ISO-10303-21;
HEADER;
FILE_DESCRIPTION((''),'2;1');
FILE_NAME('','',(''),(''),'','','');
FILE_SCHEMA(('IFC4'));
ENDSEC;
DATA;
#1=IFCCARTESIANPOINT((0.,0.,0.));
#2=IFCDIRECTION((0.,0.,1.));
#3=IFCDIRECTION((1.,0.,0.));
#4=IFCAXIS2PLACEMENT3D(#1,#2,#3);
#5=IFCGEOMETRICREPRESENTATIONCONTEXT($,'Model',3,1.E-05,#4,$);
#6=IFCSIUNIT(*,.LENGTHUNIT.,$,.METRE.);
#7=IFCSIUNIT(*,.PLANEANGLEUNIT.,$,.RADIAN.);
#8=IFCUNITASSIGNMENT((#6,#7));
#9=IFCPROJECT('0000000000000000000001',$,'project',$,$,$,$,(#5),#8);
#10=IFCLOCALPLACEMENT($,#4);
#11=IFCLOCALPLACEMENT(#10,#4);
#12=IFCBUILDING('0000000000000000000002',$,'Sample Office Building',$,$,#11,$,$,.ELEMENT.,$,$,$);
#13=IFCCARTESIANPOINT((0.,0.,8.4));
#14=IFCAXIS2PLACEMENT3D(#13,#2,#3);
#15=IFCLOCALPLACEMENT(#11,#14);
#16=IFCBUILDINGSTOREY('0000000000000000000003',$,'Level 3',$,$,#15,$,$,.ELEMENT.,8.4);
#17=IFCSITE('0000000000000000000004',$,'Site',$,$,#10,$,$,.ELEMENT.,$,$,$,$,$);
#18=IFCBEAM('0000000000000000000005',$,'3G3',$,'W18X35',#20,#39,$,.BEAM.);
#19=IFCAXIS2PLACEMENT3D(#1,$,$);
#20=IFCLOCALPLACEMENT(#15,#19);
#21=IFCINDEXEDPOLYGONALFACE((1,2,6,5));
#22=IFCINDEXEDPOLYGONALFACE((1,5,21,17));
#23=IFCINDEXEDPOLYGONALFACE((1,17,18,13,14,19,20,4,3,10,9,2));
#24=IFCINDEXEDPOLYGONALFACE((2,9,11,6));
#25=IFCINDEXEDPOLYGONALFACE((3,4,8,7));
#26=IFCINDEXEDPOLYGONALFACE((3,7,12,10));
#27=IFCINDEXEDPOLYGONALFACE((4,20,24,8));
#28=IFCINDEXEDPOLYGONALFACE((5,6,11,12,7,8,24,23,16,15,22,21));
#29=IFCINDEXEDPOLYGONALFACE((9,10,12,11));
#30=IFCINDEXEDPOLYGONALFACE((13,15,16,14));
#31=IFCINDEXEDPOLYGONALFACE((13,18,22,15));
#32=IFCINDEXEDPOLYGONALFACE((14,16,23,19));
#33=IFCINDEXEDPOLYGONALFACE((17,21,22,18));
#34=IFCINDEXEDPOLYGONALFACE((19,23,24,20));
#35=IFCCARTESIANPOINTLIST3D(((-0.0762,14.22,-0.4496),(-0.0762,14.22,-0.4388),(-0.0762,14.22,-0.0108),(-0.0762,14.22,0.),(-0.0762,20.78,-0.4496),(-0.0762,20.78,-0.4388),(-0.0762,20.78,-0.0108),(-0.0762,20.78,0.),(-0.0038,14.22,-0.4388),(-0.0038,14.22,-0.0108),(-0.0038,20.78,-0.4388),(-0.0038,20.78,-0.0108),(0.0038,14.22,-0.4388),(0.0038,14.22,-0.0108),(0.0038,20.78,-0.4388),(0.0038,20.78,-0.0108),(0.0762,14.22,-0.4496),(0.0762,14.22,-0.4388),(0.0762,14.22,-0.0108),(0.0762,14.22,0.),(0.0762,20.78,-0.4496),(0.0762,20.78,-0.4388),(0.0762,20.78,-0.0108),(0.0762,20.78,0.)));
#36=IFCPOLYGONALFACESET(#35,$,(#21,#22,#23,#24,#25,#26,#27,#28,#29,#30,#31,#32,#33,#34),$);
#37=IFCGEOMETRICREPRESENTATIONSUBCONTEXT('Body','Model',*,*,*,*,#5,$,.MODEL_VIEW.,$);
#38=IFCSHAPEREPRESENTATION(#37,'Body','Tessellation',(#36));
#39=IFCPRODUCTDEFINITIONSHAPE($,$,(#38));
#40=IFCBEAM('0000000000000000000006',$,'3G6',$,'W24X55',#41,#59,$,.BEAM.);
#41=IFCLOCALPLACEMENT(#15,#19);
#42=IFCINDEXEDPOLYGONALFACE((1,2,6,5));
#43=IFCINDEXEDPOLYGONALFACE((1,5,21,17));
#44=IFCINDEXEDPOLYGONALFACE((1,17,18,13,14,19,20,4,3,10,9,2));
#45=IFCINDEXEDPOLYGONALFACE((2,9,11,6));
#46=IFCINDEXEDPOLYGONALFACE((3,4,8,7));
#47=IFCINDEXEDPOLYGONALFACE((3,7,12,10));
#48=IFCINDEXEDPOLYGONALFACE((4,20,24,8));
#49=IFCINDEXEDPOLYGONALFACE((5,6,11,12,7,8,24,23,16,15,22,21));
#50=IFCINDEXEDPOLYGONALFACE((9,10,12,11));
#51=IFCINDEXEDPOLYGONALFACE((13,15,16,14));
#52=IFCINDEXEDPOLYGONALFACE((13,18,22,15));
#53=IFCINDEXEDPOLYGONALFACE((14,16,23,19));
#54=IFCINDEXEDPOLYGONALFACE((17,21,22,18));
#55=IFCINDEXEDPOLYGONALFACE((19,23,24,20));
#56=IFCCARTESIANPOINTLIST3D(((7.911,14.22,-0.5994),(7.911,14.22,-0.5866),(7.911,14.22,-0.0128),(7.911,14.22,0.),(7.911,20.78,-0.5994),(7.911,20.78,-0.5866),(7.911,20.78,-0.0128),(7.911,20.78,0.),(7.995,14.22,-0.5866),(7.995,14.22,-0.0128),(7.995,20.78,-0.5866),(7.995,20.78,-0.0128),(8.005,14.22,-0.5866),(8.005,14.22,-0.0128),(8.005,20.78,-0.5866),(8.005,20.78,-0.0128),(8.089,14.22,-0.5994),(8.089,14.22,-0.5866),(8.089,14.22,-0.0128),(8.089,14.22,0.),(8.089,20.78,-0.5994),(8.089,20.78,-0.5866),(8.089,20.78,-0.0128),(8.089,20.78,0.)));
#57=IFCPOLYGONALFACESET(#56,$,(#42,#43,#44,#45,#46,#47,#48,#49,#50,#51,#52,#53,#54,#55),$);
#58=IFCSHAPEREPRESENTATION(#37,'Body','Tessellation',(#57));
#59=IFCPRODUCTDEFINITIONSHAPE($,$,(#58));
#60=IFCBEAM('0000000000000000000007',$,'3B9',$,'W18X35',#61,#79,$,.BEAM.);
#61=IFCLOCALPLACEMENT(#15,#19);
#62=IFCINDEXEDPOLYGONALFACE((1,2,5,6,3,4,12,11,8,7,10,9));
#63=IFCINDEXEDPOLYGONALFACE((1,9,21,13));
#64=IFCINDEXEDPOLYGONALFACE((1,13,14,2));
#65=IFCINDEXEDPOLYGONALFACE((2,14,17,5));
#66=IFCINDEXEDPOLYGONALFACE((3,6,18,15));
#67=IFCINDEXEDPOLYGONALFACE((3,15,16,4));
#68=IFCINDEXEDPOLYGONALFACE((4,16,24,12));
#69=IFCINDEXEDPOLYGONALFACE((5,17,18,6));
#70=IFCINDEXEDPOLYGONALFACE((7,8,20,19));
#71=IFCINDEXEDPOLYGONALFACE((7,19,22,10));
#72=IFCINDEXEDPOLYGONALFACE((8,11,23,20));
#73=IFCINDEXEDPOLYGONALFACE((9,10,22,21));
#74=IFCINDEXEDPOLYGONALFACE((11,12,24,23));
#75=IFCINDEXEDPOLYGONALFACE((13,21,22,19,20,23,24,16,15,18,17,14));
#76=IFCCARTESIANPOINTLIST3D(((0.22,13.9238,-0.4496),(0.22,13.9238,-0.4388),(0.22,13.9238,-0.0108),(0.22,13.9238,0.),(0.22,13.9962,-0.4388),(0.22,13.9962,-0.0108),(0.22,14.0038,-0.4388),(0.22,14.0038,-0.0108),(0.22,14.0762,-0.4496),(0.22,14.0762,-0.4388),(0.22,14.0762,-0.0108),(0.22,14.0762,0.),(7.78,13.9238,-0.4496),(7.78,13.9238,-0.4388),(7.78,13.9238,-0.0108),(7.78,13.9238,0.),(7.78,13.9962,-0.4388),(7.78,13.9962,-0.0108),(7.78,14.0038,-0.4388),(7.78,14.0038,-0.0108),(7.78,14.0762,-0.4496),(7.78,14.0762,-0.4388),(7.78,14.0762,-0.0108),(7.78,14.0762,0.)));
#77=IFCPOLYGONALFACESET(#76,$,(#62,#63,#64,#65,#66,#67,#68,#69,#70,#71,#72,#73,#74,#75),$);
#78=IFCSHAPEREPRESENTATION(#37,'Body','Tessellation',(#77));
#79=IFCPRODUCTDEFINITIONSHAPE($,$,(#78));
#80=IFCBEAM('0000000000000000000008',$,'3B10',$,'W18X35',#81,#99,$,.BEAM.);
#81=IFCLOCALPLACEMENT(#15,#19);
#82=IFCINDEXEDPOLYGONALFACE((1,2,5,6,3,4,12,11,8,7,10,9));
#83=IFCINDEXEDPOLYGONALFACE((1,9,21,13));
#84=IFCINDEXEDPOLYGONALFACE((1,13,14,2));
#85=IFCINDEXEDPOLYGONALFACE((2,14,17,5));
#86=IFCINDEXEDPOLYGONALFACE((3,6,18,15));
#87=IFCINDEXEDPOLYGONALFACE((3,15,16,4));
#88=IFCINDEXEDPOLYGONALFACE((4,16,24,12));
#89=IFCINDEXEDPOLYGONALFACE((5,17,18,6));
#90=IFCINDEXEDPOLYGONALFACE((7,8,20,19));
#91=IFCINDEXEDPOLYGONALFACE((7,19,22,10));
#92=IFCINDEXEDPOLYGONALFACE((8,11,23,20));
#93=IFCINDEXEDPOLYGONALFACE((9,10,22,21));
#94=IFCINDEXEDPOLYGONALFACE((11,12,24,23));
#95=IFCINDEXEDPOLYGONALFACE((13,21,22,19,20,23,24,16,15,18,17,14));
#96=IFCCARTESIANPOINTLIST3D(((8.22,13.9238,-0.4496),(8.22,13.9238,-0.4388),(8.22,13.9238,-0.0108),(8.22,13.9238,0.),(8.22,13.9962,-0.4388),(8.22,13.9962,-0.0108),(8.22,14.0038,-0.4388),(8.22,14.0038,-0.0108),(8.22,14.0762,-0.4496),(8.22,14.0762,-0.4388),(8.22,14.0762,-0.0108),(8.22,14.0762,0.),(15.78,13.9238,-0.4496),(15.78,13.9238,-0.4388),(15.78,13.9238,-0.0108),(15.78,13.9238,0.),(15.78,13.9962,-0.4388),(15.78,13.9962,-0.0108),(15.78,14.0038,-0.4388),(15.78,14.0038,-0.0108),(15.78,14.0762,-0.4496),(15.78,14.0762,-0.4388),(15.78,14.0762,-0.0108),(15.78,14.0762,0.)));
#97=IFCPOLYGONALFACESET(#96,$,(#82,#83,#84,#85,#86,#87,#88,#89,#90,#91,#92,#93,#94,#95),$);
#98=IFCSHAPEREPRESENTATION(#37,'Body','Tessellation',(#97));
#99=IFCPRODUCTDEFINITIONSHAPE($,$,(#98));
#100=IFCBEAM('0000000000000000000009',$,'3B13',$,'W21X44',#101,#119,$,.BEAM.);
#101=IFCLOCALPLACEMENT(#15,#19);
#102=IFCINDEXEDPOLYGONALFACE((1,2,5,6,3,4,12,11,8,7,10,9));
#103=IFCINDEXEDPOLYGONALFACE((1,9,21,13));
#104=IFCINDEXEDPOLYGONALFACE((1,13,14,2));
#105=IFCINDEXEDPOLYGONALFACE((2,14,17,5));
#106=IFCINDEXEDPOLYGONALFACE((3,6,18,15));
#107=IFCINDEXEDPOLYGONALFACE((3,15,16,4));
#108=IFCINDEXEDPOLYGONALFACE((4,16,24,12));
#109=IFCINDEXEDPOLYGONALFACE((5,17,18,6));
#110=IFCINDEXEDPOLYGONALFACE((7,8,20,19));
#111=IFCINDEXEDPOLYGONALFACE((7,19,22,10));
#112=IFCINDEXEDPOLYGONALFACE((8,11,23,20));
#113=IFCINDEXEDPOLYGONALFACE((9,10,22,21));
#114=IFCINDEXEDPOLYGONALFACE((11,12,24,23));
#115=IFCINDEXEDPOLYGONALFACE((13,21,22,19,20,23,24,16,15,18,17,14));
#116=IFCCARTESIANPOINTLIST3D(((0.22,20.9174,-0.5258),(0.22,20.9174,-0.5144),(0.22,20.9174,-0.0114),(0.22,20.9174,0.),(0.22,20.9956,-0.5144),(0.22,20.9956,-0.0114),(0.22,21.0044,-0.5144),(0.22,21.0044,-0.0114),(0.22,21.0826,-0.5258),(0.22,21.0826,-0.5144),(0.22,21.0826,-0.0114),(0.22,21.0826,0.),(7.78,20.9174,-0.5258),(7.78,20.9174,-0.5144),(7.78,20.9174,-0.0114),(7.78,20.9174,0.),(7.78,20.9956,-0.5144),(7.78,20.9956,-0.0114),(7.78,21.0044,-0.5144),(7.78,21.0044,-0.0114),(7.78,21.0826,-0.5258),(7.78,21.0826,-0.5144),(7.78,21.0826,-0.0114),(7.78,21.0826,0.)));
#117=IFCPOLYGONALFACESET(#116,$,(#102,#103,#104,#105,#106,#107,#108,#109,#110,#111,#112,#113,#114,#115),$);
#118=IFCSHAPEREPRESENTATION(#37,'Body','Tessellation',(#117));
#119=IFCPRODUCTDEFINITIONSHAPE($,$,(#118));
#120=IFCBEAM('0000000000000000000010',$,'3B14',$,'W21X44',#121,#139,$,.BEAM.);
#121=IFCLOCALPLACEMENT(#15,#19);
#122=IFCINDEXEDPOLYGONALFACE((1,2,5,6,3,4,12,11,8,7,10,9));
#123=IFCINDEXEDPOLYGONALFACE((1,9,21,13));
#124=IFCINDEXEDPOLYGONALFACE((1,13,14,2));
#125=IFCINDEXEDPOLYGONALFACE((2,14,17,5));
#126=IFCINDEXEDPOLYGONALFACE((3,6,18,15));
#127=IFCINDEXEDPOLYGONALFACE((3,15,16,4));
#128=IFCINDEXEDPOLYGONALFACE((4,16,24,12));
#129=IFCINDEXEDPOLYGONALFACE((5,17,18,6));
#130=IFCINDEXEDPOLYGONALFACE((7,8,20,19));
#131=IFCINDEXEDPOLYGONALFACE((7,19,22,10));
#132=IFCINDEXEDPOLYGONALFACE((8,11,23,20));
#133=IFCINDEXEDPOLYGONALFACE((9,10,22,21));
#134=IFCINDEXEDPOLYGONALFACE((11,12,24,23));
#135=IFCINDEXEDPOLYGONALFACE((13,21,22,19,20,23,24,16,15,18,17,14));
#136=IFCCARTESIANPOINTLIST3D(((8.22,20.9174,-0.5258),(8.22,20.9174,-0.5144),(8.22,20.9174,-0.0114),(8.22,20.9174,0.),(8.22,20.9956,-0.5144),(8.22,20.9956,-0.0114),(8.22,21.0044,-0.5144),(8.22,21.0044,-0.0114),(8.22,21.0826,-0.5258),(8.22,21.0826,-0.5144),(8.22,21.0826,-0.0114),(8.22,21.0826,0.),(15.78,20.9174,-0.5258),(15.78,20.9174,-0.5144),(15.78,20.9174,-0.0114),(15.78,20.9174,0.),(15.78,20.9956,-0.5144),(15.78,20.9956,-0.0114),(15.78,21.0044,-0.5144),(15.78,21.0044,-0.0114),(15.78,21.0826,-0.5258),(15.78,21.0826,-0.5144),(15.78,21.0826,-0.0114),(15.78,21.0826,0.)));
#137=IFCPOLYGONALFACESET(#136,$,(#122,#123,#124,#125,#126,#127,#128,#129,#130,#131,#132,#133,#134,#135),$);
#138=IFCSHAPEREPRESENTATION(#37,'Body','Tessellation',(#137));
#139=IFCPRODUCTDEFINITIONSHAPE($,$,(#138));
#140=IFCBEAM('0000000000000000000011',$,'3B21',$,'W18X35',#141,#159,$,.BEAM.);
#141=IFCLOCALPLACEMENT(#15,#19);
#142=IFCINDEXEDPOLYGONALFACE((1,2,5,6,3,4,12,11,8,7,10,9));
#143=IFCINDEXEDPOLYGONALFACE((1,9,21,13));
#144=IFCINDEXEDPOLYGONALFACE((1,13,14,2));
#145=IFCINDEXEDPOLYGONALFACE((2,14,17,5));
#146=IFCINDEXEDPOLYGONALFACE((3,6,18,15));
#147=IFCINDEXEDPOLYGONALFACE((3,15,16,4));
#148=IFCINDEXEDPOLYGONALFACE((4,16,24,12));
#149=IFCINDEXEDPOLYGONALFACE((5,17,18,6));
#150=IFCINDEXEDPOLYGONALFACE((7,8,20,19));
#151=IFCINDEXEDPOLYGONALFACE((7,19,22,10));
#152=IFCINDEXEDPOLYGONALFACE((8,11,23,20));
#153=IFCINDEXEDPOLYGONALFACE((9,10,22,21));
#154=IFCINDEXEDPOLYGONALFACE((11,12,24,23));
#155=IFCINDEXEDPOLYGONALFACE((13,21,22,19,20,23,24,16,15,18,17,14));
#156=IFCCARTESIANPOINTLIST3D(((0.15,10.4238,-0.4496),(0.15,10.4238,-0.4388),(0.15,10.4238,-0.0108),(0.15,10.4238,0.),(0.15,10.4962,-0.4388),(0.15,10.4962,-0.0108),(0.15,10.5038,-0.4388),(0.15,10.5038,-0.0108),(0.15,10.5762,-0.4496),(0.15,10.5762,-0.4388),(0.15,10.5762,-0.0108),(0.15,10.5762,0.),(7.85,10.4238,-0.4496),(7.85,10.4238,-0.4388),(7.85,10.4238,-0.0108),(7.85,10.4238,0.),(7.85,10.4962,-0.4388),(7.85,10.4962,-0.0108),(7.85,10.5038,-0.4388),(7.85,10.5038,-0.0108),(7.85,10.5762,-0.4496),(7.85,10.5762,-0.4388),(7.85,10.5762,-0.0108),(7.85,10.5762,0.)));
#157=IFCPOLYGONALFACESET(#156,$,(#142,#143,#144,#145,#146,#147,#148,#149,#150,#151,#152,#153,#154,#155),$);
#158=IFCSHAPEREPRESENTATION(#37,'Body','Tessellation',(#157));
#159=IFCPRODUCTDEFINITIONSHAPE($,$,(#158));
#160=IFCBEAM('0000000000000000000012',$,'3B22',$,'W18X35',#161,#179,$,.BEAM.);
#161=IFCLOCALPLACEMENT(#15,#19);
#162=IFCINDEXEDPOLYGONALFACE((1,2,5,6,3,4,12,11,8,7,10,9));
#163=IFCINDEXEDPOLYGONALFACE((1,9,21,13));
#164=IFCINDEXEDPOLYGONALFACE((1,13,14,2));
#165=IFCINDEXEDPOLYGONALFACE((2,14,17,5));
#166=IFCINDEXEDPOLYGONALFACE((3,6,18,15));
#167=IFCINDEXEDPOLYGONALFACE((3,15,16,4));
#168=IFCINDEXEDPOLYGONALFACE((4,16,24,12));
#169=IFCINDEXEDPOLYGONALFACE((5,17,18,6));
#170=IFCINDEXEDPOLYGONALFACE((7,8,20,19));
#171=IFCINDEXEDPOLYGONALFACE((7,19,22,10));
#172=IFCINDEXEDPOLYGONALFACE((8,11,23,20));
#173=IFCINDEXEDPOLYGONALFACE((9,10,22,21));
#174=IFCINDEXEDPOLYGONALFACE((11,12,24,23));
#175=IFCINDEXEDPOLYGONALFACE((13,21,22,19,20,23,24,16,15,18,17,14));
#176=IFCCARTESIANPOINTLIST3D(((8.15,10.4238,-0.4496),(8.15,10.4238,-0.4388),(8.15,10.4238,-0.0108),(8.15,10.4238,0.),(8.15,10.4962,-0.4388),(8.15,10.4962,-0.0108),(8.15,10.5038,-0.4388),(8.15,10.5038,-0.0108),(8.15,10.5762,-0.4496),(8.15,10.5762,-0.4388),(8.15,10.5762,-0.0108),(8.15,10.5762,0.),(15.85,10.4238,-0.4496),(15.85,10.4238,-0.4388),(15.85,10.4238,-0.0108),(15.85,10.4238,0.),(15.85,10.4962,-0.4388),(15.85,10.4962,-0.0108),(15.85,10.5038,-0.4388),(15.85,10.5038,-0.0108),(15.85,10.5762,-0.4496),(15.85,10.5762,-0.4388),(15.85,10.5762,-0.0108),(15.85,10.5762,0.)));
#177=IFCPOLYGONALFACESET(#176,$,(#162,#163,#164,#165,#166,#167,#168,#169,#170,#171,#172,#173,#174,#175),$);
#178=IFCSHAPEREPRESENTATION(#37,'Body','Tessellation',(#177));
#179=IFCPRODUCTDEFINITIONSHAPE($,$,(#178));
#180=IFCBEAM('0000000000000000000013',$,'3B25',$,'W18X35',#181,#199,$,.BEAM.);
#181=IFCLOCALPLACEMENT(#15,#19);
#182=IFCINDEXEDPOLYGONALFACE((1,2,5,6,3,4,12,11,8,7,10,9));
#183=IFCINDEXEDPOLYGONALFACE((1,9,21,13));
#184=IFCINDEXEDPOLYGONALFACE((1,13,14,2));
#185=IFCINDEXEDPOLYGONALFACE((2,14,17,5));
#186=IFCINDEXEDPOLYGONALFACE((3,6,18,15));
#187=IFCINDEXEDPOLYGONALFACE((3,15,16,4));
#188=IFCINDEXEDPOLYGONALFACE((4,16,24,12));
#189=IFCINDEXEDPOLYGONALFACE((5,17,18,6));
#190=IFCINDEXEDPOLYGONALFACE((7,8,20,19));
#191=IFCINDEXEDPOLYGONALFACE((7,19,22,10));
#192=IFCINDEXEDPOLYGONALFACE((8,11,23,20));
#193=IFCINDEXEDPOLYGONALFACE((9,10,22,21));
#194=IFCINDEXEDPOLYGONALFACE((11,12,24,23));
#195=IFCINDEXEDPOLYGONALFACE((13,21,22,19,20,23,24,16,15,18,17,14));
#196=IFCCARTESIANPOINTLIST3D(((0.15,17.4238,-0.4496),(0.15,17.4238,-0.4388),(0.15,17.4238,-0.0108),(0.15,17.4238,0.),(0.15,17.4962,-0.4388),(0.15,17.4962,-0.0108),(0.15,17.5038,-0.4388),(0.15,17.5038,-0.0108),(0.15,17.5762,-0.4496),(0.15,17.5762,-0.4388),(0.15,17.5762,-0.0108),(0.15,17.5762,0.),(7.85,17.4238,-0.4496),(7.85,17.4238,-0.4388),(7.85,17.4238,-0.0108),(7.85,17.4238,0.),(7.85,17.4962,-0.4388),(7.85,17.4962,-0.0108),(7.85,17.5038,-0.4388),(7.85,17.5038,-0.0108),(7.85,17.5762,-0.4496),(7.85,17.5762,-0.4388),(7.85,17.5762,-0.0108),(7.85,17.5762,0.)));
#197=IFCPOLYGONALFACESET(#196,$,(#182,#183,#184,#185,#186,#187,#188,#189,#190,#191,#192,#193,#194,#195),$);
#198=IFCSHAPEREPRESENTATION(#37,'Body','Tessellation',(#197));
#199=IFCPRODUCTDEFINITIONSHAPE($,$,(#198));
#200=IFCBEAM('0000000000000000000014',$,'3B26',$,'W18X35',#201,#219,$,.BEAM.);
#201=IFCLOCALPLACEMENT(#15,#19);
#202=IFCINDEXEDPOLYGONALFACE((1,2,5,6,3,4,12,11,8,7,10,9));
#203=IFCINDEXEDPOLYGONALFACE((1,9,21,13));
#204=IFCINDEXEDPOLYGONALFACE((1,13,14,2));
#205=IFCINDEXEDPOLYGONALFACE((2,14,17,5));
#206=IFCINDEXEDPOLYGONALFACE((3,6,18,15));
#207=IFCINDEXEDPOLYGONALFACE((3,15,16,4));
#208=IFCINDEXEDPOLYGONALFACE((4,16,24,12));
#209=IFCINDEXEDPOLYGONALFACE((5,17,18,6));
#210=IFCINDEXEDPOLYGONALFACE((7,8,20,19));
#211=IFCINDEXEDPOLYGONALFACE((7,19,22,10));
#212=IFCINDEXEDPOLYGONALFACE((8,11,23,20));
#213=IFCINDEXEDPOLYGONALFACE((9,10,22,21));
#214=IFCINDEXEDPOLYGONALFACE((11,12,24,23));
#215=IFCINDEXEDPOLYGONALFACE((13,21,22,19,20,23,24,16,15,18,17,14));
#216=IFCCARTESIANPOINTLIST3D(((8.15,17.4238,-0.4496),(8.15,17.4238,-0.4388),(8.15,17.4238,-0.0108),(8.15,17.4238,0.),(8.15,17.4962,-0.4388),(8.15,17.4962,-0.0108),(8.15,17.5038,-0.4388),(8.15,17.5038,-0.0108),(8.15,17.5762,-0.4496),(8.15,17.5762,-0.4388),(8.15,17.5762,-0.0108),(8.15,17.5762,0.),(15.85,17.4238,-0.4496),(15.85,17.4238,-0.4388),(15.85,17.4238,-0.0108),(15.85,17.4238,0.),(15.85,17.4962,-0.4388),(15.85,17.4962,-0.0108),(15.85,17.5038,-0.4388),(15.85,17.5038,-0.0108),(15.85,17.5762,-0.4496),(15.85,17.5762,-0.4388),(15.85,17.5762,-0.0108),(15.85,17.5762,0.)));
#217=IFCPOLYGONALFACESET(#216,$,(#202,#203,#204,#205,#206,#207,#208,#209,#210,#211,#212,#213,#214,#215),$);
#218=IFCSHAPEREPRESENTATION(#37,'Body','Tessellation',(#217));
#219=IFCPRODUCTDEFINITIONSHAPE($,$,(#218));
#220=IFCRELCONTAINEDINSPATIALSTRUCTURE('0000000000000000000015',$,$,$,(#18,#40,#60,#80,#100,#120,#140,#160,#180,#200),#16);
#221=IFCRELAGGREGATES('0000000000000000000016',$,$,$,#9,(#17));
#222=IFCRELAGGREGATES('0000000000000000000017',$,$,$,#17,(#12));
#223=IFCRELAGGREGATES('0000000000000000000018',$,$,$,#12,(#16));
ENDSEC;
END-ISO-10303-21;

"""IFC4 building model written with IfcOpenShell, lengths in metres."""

from ifc_helpers import new_model, si_unit, frame, origin_with_axes, place, context, subcontext, project, spatial, i_section, extrude, element, save


model = new_model("IFC4")

# Units and contexts
model_context = context("Model", 3, precision=1e-05, world=origin_with_axes())
body_context = subcontext(model_context, "Body", "Model", "MODEL_VIEW")
ifc_project = project(units=[si_unit("LENGTHUNIT", "METRE"), si_unit("PLANEANGLEUNIT", "RADIAN")], contexts=[model_context])

# Site, building, storey
site_placement = place(None, origin_with_axes())
site = spatial("IfcSite", under=ifc_project, at=site_placement, Name="Site", CompositionType="ELEMENT")
building_placement = place(site_placement, origin_with_axes())
building = spatial("IfcBuilding", under=site, at=building_placement, Name="Sample Office Building", CompositionType="ELEMENT")
storey_placement = place(building_placement, frame((0.0, 0.0, 8.4), z_axis=(0.0, 0.0, 1.0), x_axis=(1.0, 0.0, 0.0)))
storey = spatial("IfcBuildingStorey", under=building, at=storey_placement, Name="Level 3", CompositionType="ELEMENT", Elevation=8.4)

# Beams
beam_1_placement = place(None, frame((0.0, 14.22, 8.1752), z_axis=(0.0, 1.0, 0.0), x_axis=(-1.0, 0.0, 0.0)))
element("IfcBeam", 1, at=beam_1_placement, inside=storey, Name="3G3", ObjectType="W18X35", PredefinedType="BEAM", context=body_context, shape_type="SweptSolid", body=[
    extrude(i_section(OverallWidth=0.1524, OverallDepth=0.4496, WebThickness=0.0076, FlangeThickness=0.0108), None, (0.0, 0.0, 1.0), 6.56),
])
beam_2_placement = place(None, frame((8.0, 14.22, 8.1003), z_axis=(0.0, 1.0, 0.0), x_axis=(-1.0, 0.0, 0.0)))
element("IfcBeam", 2, at=beam_2_placement, inside=storey, Name="3G6", ObjectType="W24X55", PredefinedType="BEAM", context=body_context, shape_type="SweptSolid", body=[
    extrude(i_section(OverallWidth=0.1781, OverallDepth=0.5994, WebThickness=0.01, FlangeThickness=0.0128), None, (0.0, 0.0, 1.0), 6.56),
])
beam_3_placement = place(None, frame((0.22, 14.0, 8.1752), z_axis=(1.0, 0.0, 0.0), x_axis=(0.0, 1.0, 0.0)))
element("IfcBeam", 3, at=beam_3_placement, inside=storey, Name="3B9", ObjectType="W18X35", PredefinedType="BEAM", context=body_context, shape_type="SweptSolid", body=[
    extrude(i_section(OverallWidth=0.1524, OverallDepth=0.4496, WebThickness=0.0076, FlangeThickness=0.0108), None, (0.0, 0.0, 1.0), 7.56),
])
beam_4_placement = place(None, frame((8.22, 14.0, 8.1752), z_axis=(1.0, 0.0, 0.0), x_axis=(0.0, 1.0, 0.0)))
element("IfcBeam", 4, at=beam_4_placement, inside=storey, Name="3B10", ObjectType="W18X35", PredefinedType="BEAM", context=body_context, shape_type="SweptSolid", body=[
    extrude(i_section(OverallWidth=0.1524, OverallDepth=0.4496, WebThickness=0.0076, FlangeThickness=0.0108), None, (0.0, 0.0, 1.0), 7.56),
])
beam_5_placement = place(None, frame((0.22, 21.0, 8.1371), z_axis=(1.0, 0.0, 0.0), x_axis=(0.0, 1.0, 0.0)))
element("IfcBeam", 5, at=beam_5_placement, inside=storey, Name="3B13", ObjectType="W21X44", PredefinedType="BEAM", context=body_context, shape_type="SweptSolid", body=[
    extrude(i_section(OverallWidth=0.1651, OverallDepth=0.5258, WebThickness=0.0089, FlangeThickness=0.0114), None, (0.0, 0.0, 1.0), 7.56),
])
beam_6_placement = place(None, frame((8.22, 21.0, 8.1371), z_axis=(1.0, 0.0, 0.0), x_axis=(0.0, 1.0, 0.0)))
element("IfcBeam", 6, at=beam_6_placement, inside=storey, Name="3B14", ObjectType="W21X44", PredefinedType="BEAM", context=body_context, shape_type="SweptSolid", body=[
    extrude(i_section(OverallWidth=0.1651, OverallDepth=0.5258, WebThickness=0.0089, FlangeThickness=0.0114), None, (0.0, 0.0, 1.0), 7.56),
])
for number, where, z_axis, x_axis, name in (
    (7, (0.15, 10.5, 8.1752), (1.0, 0.0, 0.0), (0.0, 1.0, 0.0), "3B21"),
    (8, (8.15, 10.5, 8.1752), (1.0, 0.0, 0.0), (0.0, 1.0, 0.0), "3B22"),
    (9, (0.15, 17.5, 8.1752), (1.0, 0.0, 0.0), (0.0, 1.0, 0.0), "3B25"),
    (10, (8.15, 17.5, 8.1752), (1.0, 0.0, 0.0), (0.0, 1.0, 0.0), "3B26"),
):
    element("IfcBeam", number, at=place(None, frame(where, z_axis=z_axis, x_axis=x_axis)), inside=storey, Name=name, ObjectType="W18X35", PredefinedType="BEAM", context=body_context, shape_type="SweptSolid", body=[
        extrude(i_section(OverallWidth=0.1524, OverallDepth=0.4496, WebThickness=0.0076, FlangeThickness=0.0108), None, (0.0, 0.0, 1.0), 7.7),
    ])

save(model, "model.ifc")
